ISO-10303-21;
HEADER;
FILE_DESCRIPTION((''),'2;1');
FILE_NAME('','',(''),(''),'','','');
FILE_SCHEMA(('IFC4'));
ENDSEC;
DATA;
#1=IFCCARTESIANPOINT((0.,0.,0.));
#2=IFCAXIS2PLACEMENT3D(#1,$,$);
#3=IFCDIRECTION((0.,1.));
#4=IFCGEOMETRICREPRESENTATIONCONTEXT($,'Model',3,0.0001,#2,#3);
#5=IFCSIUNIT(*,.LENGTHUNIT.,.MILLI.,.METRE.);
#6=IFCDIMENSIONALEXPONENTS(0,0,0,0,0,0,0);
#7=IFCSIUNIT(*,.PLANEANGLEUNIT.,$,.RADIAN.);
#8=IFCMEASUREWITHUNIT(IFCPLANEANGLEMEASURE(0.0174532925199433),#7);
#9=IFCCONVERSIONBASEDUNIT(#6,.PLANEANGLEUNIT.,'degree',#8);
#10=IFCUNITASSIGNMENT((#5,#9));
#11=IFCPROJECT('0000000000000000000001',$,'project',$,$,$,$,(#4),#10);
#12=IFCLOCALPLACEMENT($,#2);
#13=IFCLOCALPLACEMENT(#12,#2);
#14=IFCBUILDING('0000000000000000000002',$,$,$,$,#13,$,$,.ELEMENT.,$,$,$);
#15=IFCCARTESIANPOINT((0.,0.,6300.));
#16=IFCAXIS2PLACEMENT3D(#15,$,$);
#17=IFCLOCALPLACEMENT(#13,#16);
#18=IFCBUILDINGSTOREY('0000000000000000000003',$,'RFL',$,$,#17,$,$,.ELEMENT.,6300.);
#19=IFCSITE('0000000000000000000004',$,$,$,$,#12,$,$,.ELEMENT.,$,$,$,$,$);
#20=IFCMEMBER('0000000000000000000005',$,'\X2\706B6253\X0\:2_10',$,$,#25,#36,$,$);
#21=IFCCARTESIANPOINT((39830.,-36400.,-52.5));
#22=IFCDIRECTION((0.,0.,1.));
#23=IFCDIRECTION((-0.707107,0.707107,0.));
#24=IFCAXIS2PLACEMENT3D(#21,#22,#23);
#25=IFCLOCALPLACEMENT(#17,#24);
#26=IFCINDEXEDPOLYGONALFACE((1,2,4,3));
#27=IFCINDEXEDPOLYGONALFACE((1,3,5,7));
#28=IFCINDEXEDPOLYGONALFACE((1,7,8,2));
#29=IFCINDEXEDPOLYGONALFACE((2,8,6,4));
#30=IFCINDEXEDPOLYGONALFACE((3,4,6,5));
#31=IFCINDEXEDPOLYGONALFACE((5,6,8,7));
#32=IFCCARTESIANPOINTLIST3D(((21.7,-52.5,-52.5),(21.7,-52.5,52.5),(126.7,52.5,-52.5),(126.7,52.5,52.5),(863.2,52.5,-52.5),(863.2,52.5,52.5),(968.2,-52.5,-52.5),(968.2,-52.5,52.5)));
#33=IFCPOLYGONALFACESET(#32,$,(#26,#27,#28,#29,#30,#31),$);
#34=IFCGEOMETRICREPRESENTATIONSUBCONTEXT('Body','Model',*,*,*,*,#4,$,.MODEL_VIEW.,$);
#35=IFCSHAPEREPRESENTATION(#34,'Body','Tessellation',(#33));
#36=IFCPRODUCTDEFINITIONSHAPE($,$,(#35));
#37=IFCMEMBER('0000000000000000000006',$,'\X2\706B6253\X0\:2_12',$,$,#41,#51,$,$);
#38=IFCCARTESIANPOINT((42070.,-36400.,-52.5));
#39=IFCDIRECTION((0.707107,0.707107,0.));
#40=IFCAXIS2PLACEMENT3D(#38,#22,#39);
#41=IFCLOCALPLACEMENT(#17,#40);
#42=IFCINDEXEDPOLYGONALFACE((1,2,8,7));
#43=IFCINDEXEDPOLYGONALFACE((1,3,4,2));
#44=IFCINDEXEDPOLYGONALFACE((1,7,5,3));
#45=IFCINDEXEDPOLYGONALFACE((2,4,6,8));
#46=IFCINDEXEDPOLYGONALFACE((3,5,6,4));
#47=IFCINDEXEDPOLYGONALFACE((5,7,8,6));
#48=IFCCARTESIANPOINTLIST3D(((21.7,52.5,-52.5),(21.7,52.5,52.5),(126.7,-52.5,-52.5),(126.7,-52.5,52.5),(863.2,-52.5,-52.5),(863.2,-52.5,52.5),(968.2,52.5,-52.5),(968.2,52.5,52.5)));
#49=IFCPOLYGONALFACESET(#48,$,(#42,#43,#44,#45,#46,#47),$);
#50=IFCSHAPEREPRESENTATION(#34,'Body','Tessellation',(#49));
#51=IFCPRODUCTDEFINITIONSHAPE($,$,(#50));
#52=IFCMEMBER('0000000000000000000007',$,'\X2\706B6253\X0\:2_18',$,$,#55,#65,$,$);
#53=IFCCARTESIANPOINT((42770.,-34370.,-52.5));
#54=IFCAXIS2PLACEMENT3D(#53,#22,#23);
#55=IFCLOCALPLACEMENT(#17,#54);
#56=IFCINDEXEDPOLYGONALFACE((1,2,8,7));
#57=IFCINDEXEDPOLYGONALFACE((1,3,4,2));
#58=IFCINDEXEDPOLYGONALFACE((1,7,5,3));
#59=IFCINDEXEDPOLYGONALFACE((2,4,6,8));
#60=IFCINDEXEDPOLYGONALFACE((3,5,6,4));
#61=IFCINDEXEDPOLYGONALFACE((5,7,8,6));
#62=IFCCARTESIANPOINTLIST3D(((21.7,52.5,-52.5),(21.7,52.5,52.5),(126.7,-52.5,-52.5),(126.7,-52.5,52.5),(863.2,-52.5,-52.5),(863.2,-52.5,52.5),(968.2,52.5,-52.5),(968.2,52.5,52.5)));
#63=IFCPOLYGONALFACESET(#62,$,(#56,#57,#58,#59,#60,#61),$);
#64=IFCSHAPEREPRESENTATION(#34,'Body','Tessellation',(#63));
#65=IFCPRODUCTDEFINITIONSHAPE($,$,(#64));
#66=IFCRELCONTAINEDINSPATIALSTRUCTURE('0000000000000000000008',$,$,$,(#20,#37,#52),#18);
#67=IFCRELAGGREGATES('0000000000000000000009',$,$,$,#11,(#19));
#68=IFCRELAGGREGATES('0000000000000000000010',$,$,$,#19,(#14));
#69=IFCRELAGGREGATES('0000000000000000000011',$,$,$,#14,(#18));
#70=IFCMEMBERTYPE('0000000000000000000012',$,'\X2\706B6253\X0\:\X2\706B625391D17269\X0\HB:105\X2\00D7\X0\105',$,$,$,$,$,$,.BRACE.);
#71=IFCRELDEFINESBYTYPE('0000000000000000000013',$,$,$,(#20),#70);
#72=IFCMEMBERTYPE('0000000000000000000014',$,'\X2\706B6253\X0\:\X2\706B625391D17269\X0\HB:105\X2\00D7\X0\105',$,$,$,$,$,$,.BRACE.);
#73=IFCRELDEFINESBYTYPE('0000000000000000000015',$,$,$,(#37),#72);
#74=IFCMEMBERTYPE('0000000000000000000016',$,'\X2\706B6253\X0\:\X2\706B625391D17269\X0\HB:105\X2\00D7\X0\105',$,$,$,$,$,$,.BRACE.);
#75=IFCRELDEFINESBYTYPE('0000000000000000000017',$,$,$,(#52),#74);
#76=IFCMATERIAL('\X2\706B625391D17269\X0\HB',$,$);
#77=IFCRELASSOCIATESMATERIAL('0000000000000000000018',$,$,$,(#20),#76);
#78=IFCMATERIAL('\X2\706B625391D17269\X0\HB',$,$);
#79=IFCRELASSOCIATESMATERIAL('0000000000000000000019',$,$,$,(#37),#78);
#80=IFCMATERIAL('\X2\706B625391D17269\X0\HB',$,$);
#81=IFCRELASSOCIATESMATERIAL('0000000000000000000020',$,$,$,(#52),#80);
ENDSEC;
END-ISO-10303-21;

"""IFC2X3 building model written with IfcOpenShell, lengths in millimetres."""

from ifc_helpers import new_model, entity, si_unit, converted_unit, direction, frame, origin, place, context, subcontext, project, spatial, polyline, outline, extrude, material, type_object, element, save


model = new_model("IFC2X3")

# Units and contexts
model_context = context("Model", 3, precision=0.0001, world=origin(), true_north=direction((0.0, 1.0)))
body_context = subcontext(model_context, "Body", "Model", "MODEL_VIEW")
ifc_project = project(units=[si_unit("LENGTHUNIT", "METRE", prefix="MILLI"), converted_unit("PLANEANGLEUNIT", "degree", entity("IfcPlaneAngleMeasure", 0.0174532925199433), si_unit("PLANEANGLEUNIT", "RADIAN"), dimensions=[0, 0, 0, 0, 0, 0, 0])], contexts=[model_context])

# Site, building, storey
site_placement = place(None, origin())
site = spatial("IfcSite", under=ifc_project, at=site_placement, CompositionType="ELEMENT")
building_placement = place(site_placement, origin())
building = spatial("IfcBuilding", under=site, at=building_placement, CompositionType="ELEMENT")
storey_placement = place(building_placement, frame((0.0, 0.0, 6300.0)))
storey = spatial("IfcBuildingStorey", under=building, at=storey_placement, Name="RFL", CompositionType="ELEMENT", Elevation=6300.0)

# Members
ifc_material_1 = material(Name="火打金物HB")
member_type_1 = type_object("IfcMemberType", Name="火打:火打金物HB:105×105", PredefinedType="BRACE")
member_1_placement = place(storey_placement, frame((39830.0, -36400.0, -52.5), z_axis=(0.0, 0.0, 1.0), x_axis=(-0.707107, 0.707107, 0.0)))
element("IfcMember", 1, at=member_1_placement, inside=storey, type_object=member_type_1, material=ifc_material_1, Name="火打:2_10", context=body_context, shape_type="SweptSolid", body=[
    extrude(outline(polyline([(21.7, -52.5, 0.0), (126.7, 52.5, 0.0), (863.2, 52.5, 0.0), (968.2, -52.5, 0.0), (21.7, -52.5, 0.0)])), frame((0.0, 0.0, -52.5), z_axis=(0.0, 0.0, 1.0), x_axis=(1.0, 0.0, 0.0)), (0.0, 0.0, 1.0), 105.0),
])
ifc_material_2 = material(Name="火打金物HB")
member_type_2 = type_object("IfcMemberType", Name="火打:火打金物HB:105×105", PredefinedType="BRACE")
member_2_placement = place(storey_placement, frame((42070.0, -36400.0, -52.5), z_axis=(0.0, 0.0, 1.0), x_axis=(0.707107, 0.707107, 0.0)))
element("IfcMember", 2, at=member_2_placement, inside=storey, type_object=member_type_2, material=ifc_material_2, Name="火打:2_12", context=body_context, shape_type="SweptSolid", body=[
    extrude(outline(polyline([(126.7, -52.5, 0.0), (21.7, 52.5, 0.0), (968.2, 52.5, 0.0), (863.2, -52.5, 0.0), (126.7, -52.5, 0.0)])), frame((0.0, 0.0, -52.5), z_axis=(0.0, 0.0, 1.0), x_axis=(1.0, 0.0, 0.0)), (0.0, 0.0, 1.0), 105.0),
])
ifc_material_3 = material(Name="火打金物HB")
member_type_3 = type_object("IfcMemberType", Name="火打:火打金物HB:105×105", PredefinedType="BRACE")
member_3_placement = place(storey_placement, frame((42770.0, -34370.0, -52.5), z_axis=(0.0, 0.0, 1.0), x_axis=(-0.707107, 0.707107, 0.0)))
element("IfcMember", 3, at=member_3_placement, inside=storey, type_object=member_type_3, material=ifc_material_3, Name="火打:2_18", context=body_context, shape_type="SweptSolid", body=[
    extrude(outline(polyline([(126.7, -52.5, 0.0), (21.7, 52.5, 0.0), (968.2, 52.5, 0.0), (863.2, -52.5, 0.0), (126.7, -52.5, 0.0)])), frame((0.0, 0.0, -52.5), z_axis=(0.0, 0.0, 1.0), x_axis=(1.0, 0.0, 0.0)), (0.0, 0.0, 1.0), 105.0),
])

save(model, "model.ifc")
